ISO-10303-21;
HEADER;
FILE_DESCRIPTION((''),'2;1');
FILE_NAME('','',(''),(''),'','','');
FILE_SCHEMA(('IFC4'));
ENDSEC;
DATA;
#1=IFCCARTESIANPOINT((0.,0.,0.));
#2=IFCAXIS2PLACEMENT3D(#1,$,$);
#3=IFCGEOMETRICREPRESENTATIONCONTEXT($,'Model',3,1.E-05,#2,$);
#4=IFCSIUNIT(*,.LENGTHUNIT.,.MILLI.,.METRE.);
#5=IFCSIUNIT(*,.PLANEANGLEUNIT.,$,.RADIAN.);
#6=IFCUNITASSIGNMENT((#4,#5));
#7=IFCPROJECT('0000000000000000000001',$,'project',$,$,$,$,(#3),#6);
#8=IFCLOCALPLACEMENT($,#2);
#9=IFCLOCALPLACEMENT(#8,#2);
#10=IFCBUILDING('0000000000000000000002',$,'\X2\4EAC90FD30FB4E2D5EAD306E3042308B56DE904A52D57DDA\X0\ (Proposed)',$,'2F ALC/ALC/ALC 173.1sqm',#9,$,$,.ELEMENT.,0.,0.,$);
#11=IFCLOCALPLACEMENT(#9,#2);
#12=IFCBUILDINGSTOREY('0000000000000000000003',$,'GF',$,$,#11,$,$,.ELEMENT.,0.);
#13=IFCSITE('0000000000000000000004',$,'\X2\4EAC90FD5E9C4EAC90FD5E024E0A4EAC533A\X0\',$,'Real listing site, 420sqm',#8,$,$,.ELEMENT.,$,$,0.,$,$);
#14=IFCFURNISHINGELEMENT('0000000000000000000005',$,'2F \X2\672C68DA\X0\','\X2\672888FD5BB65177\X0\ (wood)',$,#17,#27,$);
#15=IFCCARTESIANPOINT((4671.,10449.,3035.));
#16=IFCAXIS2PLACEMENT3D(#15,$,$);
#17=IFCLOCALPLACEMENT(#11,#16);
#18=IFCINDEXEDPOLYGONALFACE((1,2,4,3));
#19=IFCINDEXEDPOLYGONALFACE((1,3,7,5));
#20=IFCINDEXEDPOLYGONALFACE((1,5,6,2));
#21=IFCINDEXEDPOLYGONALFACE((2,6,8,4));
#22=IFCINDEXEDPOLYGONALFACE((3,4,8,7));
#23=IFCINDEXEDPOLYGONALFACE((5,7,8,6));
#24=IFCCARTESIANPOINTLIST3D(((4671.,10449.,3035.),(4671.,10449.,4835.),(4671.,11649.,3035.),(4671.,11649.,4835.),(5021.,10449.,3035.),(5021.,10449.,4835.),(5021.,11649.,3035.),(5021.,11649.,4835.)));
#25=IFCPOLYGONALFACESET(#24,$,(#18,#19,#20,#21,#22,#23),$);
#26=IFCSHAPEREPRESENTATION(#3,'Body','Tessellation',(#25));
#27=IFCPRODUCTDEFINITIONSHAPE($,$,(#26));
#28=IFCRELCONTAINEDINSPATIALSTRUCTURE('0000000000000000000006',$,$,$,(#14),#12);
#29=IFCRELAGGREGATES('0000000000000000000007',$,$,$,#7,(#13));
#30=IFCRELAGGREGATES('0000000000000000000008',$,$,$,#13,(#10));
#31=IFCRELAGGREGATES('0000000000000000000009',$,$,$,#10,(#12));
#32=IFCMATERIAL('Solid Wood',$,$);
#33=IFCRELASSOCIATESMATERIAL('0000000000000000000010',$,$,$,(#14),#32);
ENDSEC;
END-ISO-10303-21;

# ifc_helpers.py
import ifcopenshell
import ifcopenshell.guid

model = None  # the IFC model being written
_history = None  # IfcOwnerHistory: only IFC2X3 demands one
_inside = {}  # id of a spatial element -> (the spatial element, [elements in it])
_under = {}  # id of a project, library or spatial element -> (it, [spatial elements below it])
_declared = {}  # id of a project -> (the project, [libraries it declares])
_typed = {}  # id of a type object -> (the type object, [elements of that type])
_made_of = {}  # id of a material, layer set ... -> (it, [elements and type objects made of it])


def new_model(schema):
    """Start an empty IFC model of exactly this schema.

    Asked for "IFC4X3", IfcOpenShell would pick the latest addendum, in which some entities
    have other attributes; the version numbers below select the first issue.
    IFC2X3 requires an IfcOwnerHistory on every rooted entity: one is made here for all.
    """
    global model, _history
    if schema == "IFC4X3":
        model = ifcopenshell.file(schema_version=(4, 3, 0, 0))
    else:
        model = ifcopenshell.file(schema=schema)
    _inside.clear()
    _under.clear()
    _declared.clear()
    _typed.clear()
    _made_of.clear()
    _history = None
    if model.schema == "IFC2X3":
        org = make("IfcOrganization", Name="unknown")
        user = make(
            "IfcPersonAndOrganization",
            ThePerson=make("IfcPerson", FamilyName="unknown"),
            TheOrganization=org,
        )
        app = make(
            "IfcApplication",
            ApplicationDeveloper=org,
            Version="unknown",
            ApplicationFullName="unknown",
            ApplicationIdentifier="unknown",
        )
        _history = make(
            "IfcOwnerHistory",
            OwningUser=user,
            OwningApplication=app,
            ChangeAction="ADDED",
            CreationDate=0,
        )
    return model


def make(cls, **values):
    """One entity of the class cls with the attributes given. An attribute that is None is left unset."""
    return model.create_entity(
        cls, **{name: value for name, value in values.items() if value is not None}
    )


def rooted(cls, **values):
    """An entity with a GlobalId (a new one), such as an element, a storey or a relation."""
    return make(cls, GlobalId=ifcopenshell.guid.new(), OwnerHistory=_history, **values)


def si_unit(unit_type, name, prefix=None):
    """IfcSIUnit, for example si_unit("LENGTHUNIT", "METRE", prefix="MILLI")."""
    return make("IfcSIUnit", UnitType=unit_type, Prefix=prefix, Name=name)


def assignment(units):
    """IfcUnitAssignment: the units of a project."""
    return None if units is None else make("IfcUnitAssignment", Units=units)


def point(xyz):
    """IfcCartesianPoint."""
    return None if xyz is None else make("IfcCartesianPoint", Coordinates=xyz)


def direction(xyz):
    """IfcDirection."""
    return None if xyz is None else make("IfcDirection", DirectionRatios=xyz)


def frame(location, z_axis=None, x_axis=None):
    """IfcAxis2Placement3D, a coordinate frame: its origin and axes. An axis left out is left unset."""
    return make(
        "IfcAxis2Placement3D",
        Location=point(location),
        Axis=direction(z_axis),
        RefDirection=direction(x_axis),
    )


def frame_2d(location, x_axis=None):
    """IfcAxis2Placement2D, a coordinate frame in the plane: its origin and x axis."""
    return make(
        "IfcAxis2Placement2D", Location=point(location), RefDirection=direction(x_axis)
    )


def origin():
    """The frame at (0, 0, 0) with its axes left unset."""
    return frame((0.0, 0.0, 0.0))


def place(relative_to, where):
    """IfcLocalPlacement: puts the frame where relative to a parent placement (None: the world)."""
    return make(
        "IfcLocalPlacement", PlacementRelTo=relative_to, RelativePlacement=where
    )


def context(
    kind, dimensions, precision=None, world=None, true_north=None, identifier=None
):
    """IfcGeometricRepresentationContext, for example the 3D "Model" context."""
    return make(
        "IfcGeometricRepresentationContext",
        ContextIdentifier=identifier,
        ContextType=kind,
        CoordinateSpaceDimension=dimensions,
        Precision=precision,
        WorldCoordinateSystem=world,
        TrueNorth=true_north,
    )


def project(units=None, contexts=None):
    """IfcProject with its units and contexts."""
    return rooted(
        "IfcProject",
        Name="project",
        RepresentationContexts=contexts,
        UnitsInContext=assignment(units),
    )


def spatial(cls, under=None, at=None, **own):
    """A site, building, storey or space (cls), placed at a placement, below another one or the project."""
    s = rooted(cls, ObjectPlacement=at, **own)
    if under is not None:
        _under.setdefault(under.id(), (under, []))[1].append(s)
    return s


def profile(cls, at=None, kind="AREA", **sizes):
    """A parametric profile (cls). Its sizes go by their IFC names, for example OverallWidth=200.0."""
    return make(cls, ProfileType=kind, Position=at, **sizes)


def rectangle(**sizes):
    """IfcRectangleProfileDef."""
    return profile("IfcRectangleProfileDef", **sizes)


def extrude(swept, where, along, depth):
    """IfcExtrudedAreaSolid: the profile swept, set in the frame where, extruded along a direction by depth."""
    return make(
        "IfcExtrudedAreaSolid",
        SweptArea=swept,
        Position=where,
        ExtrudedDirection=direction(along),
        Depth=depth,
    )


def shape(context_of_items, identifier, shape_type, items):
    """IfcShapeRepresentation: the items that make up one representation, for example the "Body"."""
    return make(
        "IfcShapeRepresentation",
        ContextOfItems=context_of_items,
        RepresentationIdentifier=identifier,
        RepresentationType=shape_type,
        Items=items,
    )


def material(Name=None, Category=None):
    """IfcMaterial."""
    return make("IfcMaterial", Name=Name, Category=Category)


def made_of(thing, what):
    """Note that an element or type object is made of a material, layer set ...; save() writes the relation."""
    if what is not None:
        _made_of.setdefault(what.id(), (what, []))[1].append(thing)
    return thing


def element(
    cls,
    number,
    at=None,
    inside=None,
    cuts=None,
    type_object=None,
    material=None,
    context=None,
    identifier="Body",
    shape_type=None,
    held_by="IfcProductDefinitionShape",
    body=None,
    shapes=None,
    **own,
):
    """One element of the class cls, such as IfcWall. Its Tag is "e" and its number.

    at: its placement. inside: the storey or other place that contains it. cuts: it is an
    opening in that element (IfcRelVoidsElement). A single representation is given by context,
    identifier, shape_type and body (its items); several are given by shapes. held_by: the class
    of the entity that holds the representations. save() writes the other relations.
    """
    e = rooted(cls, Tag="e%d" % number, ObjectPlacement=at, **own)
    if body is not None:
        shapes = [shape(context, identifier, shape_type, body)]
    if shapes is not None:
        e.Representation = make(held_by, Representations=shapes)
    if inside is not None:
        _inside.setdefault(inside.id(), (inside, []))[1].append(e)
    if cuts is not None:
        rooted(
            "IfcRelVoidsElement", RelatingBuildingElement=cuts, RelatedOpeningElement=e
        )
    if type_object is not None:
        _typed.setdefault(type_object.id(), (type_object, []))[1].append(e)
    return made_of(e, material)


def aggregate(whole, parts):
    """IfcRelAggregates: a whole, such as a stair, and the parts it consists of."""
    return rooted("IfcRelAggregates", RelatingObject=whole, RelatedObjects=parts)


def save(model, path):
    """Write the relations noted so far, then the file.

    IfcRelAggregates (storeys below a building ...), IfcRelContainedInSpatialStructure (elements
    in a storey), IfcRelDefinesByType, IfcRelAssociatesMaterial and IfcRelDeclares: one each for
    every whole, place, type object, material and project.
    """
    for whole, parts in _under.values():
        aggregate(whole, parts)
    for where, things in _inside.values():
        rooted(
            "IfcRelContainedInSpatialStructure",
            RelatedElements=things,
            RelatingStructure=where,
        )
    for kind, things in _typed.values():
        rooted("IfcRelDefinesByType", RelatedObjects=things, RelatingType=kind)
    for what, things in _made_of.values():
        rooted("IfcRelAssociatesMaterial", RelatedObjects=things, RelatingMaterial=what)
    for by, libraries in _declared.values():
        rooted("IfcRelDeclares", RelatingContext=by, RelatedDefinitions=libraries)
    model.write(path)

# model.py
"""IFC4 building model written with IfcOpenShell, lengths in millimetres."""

from ifc_helpers import new_model, si_unit, frame, frame_2d, origin, place, context, project, spatial, rectangle, extrude, material, element, save


model = new_model("IFC4")

# Units and contexts
model_context = context("Model", 3, precision=1e-05, world=origin())
ifc_project = project(units=[si_unit("LENGTHUNIT", "METRE", prefix="MILLI"), si_unit("PLANEANGLEUNIT", "RADIAN")], contexts=[model_context])

# Site, building, storey
site_placement = place(None, origin())
site = spatial("IfcSite", under=ifc_project, at=site_placement, Name="京都府京都市上京区", ObjectType="Real listing site, 420sqm", CompositionType="ELEMENT", RefElevation=0.0)
building_placement = place(site_placement, origin())
building = spatial("IfcBuilding", under=site, at=building_placement, Name="京都・中庭のある回遊動線 (Proposed)", ObjectType="2F ALC/ALC/ALC 173.1sqm", CompositionType="ELEMENT", ElevationOfRefHeight=0.0, ElevationOfTerrain=0.0)
storey_placement = place(building_placement, origin())
storey = spatial("IfcBuildingStorey", under=building, at=storey_placement, Name="GF", CompositionType="ELEMENT", Elevation=0.0)

# Shared definitions
ifc_material_1 = material(Name="Solid Wood")

# Furnishing element
furnishing_1_placement = place(storey_placement, frame((4671.0, 10449.0, 3035.0)))
element("IfcFurnishingElement", 1, at=furnishing_1_placement, inside=storey, material=ifc_material_1, Name="2F 本棚", Description="木製家具 (wood)", context=model_context, shape_type="SweptSolid", body=[
    extrude(rectangle(XDim=350.0, YDim=1200.0, at=frame_2d((175.0, 600.0))), frame((4671.0, 10449.0, 3035.0)), (0.0, 0.0, 1.0), 1800.0),
])

save(model, "model.ifc")
